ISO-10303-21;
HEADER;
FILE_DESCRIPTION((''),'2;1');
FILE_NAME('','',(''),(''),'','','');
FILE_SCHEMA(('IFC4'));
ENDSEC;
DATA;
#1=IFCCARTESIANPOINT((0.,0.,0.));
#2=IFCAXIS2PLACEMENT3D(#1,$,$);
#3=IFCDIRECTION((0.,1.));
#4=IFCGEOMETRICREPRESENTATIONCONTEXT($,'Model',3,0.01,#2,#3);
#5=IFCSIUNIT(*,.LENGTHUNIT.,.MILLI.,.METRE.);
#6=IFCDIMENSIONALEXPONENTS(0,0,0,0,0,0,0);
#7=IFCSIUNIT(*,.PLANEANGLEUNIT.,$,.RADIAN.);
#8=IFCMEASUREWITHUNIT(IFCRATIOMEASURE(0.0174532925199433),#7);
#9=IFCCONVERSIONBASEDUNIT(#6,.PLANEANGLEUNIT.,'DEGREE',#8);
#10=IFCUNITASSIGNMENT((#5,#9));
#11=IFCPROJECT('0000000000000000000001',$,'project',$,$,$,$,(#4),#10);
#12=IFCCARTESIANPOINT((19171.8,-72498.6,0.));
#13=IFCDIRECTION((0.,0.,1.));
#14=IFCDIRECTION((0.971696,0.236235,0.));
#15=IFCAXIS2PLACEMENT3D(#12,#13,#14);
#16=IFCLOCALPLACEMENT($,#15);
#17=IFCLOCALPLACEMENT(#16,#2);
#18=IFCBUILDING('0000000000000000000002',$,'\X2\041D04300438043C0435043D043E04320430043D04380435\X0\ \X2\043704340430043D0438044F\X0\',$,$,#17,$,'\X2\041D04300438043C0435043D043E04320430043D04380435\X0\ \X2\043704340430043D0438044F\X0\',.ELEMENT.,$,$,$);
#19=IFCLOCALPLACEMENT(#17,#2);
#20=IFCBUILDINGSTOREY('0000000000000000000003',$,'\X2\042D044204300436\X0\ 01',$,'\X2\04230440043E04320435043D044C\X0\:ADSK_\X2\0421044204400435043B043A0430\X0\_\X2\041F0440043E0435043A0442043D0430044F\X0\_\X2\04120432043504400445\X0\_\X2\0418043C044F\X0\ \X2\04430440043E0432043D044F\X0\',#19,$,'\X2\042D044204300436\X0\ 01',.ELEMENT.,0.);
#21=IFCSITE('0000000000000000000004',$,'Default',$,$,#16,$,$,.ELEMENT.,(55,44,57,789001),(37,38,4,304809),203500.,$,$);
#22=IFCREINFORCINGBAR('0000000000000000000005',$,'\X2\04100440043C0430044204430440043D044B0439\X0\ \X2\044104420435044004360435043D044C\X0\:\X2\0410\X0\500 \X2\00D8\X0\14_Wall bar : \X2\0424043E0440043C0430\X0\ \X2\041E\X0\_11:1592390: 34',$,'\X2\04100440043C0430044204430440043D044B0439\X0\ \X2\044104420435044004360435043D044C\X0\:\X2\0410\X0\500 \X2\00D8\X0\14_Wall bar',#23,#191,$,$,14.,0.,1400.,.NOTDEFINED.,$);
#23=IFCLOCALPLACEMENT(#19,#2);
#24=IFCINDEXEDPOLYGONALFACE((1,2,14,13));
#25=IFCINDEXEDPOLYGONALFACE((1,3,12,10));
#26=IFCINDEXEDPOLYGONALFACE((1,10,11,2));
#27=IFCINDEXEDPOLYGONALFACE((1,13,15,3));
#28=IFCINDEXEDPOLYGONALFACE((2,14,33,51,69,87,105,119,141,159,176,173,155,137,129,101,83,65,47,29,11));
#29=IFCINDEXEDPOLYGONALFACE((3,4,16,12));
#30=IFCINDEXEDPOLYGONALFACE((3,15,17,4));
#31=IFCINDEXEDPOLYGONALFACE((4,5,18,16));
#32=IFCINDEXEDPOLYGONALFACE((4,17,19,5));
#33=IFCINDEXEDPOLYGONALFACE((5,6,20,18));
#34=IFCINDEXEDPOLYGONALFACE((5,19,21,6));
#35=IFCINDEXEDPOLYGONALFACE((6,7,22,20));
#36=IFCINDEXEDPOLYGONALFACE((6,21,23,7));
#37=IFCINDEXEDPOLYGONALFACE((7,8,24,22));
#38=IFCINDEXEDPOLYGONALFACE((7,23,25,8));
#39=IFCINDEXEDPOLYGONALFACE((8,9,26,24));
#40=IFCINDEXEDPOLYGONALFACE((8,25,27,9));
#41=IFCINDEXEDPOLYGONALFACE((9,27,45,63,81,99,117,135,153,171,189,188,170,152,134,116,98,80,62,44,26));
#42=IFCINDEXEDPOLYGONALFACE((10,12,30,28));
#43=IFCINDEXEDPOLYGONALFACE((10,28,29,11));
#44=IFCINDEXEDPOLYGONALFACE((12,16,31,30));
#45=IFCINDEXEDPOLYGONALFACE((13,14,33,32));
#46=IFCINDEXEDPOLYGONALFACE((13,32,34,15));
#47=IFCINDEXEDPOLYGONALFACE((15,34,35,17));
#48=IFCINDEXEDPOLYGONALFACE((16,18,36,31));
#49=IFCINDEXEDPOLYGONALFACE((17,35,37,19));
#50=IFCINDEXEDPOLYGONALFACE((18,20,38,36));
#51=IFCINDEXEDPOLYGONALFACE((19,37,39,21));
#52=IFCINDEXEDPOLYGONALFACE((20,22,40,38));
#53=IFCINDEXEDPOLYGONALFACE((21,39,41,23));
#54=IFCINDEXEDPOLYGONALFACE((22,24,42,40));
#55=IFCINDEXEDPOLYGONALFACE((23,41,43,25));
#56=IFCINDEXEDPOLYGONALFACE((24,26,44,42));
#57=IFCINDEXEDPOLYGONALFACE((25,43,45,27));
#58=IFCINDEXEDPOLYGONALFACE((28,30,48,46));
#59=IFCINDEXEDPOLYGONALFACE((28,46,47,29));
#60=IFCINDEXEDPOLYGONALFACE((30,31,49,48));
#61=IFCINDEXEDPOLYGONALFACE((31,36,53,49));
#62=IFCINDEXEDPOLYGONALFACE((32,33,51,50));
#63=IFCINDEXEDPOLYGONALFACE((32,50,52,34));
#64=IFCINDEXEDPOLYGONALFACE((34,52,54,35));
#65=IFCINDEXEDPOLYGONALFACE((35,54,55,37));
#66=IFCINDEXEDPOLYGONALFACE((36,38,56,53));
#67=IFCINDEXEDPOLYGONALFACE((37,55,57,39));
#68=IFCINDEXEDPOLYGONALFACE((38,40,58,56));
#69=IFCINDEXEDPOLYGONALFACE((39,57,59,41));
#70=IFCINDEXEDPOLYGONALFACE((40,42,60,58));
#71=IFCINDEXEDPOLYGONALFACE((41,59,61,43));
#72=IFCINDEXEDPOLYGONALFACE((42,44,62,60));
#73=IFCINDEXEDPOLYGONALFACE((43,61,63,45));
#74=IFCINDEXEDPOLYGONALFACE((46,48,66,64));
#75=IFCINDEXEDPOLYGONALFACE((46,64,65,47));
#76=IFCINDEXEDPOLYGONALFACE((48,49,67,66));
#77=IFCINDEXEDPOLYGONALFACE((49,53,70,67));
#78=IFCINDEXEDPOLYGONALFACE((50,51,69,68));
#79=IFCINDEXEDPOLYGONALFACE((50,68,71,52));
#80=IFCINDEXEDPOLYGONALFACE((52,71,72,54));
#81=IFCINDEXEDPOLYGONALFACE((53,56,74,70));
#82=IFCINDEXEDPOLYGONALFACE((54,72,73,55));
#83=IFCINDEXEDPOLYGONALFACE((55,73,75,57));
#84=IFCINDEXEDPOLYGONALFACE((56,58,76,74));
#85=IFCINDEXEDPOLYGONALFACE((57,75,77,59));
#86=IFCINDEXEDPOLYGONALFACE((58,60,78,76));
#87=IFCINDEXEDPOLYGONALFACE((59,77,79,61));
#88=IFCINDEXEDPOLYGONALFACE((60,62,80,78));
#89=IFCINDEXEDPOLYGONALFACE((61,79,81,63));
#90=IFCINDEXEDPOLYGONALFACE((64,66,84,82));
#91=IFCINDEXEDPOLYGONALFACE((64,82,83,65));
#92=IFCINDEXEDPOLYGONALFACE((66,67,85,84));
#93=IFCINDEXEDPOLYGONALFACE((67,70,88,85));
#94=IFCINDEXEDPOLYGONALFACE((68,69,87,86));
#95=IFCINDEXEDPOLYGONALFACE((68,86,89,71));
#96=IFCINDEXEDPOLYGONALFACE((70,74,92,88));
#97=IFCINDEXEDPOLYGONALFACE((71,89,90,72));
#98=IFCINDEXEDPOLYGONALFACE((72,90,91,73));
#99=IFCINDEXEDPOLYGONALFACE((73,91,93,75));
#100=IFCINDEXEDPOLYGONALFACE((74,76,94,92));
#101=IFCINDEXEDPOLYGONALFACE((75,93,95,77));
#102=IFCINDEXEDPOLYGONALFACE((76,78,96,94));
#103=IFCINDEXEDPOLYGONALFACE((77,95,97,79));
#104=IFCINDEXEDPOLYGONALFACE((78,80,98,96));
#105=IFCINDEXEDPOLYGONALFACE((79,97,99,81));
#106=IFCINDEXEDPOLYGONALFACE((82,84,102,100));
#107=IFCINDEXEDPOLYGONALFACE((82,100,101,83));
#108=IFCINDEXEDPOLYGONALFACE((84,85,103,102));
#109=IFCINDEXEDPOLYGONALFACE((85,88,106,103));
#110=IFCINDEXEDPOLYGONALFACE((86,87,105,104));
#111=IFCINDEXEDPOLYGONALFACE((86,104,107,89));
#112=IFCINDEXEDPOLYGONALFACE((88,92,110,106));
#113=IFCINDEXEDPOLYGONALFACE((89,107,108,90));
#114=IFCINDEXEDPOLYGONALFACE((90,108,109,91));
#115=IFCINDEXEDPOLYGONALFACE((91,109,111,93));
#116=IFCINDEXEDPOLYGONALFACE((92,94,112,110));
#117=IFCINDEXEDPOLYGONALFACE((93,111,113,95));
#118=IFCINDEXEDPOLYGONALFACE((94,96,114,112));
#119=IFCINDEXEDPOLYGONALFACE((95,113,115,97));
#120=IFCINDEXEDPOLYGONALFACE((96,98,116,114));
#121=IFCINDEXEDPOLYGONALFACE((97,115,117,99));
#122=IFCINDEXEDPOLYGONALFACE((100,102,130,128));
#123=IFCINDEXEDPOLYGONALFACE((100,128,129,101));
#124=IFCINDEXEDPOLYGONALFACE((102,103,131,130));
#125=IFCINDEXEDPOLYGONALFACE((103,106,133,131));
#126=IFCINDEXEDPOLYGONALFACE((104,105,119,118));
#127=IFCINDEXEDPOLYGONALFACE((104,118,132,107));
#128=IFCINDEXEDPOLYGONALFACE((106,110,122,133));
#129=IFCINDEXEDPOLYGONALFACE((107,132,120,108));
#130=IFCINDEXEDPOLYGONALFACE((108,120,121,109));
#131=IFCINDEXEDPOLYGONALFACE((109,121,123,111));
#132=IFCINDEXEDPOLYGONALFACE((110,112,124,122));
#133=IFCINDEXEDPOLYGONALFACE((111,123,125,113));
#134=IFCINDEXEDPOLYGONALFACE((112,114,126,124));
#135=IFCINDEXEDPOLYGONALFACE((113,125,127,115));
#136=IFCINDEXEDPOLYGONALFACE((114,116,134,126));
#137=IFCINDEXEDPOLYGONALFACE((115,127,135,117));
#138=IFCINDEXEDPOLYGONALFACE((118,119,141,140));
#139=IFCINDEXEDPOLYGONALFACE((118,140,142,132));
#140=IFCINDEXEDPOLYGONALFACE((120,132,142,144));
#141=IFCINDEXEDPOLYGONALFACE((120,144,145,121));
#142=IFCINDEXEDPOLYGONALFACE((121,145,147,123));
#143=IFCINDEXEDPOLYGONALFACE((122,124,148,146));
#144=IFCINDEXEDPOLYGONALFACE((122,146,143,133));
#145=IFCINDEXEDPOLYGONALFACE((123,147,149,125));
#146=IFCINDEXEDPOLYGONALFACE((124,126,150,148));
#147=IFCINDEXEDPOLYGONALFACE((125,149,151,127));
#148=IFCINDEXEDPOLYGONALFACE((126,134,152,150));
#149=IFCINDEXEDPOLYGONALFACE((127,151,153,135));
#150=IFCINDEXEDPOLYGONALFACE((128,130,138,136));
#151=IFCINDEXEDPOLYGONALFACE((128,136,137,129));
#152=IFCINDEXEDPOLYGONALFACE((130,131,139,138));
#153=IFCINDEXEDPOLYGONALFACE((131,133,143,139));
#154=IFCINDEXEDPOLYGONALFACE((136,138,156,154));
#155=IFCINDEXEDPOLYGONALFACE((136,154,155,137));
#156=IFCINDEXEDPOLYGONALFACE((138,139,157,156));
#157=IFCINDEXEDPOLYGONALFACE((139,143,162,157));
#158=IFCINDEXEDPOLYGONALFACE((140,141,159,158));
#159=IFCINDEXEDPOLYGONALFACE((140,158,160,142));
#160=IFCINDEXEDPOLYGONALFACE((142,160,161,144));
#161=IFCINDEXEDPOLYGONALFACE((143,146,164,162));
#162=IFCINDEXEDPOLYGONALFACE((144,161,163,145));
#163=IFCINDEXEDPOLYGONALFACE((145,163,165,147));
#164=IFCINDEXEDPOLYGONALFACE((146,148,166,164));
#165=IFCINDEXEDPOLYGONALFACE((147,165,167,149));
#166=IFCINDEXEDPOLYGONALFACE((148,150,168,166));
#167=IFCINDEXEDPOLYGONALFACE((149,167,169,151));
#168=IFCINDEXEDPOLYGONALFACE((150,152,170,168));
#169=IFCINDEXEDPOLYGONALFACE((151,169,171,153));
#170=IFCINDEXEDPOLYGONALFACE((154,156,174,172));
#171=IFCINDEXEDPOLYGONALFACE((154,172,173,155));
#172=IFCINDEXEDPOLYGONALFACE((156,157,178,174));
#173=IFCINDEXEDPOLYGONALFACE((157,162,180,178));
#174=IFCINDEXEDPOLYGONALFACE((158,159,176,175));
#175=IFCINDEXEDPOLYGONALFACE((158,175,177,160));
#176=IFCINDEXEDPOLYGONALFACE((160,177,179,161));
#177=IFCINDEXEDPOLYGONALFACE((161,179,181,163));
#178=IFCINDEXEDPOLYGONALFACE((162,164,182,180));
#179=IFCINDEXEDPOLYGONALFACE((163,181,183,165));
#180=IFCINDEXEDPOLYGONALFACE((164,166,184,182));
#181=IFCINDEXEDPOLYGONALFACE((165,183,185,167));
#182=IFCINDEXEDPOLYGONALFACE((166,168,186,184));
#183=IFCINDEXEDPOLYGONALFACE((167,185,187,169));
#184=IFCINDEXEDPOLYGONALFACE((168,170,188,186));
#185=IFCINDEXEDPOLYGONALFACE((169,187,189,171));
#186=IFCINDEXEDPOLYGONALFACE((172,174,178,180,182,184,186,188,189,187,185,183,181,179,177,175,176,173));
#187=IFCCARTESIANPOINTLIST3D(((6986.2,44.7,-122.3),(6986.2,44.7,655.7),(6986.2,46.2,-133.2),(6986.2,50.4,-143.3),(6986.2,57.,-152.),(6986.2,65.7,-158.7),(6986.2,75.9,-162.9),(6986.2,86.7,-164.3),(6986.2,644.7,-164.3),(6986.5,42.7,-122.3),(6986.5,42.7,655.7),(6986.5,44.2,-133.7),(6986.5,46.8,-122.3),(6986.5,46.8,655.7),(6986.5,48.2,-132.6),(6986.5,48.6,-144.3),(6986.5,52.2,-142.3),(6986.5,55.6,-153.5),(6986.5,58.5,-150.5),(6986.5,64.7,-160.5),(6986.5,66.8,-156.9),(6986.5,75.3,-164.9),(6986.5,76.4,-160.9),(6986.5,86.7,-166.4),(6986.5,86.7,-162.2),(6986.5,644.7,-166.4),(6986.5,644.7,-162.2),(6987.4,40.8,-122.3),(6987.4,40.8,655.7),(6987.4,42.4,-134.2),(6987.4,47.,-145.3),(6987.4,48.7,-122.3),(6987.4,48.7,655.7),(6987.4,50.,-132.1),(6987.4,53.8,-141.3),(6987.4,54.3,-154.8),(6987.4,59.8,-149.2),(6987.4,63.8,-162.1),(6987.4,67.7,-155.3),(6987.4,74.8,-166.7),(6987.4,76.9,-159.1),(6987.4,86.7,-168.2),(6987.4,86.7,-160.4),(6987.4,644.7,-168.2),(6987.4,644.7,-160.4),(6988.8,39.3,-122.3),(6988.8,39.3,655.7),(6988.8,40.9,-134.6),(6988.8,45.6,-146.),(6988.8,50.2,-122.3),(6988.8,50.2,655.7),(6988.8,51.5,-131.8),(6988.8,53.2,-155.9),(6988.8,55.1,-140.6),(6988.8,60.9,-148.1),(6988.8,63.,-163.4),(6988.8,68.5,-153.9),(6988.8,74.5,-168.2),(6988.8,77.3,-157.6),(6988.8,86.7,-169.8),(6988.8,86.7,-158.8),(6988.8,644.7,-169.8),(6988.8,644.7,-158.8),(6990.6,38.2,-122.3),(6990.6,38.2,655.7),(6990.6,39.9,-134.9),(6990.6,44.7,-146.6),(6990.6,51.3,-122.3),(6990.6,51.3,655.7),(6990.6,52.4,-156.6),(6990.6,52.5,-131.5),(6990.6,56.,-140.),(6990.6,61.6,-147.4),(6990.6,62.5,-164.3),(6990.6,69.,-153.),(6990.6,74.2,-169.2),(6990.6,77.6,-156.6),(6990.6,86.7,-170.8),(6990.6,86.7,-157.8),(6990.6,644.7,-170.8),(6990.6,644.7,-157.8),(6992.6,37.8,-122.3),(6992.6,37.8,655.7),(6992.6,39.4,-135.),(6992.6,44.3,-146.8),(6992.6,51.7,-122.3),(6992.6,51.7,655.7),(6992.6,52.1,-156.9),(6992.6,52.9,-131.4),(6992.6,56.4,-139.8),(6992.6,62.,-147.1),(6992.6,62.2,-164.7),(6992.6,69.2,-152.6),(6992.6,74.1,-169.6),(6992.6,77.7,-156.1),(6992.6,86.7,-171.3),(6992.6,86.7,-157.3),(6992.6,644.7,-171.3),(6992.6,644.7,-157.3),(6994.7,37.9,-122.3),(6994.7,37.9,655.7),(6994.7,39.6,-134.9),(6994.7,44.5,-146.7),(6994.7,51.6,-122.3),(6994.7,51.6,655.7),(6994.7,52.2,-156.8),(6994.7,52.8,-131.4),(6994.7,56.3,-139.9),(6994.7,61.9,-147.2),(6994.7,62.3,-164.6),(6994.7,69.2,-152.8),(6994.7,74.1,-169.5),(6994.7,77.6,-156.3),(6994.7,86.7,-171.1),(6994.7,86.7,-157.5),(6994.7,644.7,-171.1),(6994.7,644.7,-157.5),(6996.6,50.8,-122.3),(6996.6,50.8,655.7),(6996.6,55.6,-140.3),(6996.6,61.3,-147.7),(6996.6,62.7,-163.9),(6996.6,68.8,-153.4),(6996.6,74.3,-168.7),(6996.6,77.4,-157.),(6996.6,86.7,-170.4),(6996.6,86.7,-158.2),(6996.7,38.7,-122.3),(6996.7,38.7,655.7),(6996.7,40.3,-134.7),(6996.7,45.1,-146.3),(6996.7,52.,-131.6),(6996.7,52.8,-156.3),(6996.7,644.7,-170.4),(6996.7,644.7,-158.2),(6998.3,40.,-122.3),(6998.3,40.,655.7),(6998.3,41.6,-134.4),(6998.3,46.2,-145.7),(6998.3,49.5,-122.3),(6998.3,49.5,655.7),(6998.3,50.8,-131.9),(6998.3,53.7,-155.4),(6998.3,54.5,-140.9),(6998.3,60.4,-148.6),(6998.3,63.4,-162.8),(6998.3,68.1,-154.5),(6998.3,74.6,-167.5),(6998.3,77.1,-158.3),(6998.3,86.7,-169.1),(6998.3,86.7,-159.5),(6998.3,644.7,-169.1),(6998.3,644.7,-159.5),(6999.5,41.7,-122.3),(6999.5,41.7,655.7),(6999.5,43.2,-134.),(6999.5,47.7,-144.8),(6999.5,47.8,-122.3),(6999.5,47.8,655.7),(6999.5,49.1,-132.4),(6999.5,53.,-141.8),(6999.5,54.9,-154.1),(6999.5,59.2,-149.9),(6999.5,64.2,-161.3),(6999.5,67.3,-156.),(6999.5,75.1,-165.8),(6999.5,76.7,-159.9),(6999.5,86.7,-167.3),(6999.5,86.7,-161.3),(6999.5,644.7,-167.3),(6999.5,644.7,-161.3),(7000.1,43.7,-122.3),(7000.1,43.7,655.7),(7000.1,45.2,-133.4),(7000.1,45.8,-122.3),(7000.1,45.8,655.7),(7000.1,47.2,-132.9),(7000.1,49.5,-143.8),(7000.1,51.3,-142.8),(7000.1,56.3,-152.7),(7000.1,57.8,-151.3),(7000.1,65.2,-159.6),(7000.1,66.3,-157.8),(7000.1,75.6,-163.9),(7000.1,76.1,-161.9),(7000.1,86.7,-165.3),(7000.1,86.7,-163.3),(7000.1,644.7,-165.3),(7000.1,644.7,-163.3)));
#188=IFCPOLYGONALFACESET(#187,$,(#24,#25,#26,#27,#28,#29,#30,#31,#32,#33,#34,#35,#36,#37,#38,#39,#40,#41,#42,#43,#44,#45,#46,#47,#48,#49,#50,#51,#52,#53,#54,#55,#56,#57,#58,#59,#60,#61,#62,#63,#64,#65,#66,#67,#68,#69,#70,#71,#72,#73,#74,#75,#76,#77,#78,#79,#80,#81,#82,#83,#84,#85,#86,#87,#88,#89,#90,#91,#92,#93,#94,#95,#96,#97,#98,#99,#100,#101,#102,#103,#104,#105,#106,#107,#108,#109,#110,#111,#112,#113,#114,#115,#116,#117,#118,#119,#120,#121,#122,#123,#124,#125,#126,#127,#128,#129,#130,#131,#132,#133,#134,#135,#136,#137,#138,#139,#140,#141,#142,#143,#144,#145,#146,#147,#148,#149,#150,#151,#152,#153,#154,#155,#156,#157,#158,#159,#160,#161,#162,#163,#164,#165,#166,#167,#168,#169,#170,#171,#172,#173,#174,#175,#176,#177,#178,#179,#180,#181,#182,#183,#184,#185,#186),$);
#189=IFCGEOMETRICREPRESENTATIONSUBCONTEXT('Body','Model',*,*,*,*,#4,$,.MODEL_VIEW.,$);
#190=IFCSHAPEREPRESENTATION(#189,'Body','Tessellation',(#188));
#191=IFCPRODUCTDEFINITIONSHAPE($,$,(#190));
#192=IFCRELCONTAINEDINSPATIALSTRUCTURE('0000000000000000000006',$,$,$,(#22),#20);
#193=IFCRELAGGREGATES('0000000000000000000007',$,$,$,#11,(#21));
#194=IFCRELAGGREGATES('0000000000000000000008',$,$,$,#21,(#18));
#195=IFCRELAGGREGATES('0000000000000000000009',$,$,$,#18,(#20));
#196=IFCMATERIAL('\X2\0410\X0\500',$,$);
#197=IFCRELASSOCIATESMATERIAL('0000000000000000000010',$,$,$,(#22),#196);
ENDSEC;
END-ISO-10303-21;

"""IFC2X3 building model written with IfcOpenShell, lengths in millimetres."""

from ifc_helpers import new_model, entity, si_unit, converted_unit, direction, frame, origin, place, context, subcontext, project, spatial, material, element, save


model = new_model("IFC2X3")

# Units and contexts
model_context = context("Model", 3, precision=0.01, world=origin(), true_north=direction((0.0, 1.0)))
body_context = subcontext(model_context, "Body", "Model", "MODEL_VIEW")
ifc_project = project(units=[si_unit("LENGTHUNIT", "METRE", prefix="MILLI"), converted_unit("PLANEANGLEUNIT", "DEGREE", entity("IfcRatioMeasure", 0.0174532925199433), si_unit("PLANEANGLEUNIT", "RADIAN"), dimensions=[0, 0, 0, 0, 0, 0, 0])], contexts=[model_context])

# Site, building, storey
site_placement = place(None, frame((19171.8, -72498.6, 0.0), z_axis=(0.0, 0.0, 1.0), x_axis=(0.971696, 0.236235, 0.0)))
site = spatial("IfcSite", under=ifc_project, at=site_placement, Name="Default", CompositionType="ELEMENT", RefLatitude=(55, 44, 57, 789001), RefLongitude=(37, 38, 4, 304809), RefElevation=203500.0)
building_placement = place(site_placement, origin())
building = spatial("IfcBuilding", under=site, at=building_placement, Name="Наименование здания", LongName="Наименование здания", CompositionType="ELEMENT")
storey_placement = place(building_placement, origin())
storey = spatial("IfcBuildingStorey", under=building, at=storey_placement, Name="Этаж 01", ObjectType="Уровень:ADSK_Стрелка_Проектная_Вверх_Имя уровня", LongName="Этаж 01", CompositionType="ELEMENT", Elevation=0.0)

# Reinforcing bar
ifc_material = material(Name="А500")
placement = place(storey_placement, origin())
element("IfcReinforcingBar", 1, at=placement, inside=storey, material=ifc_material, Name="Арматурный стержень:А500 Ø14_Wall bar : Форма О_11:1592390: 34", ObjectType="Арматурный стержень:А500 Ø14_Wall bar", BarLength=1400.0, BarRole="NOTDEFINED", CrossSectionArea=0.0, NominalDiameter=14.0, context=body_context, shape_type="AdvancedSweptSolid", body=[
    entity("IfcSweptDiskSolid", entity("IfcCompositeCurve", [entity("IfcCompositeCurveSegment", "CONTINUOUS", True, entity("IfcPolyline", [entity("IfcCartesianPoint", [6993.1, 44.7, 655.7]), entity("IfcCartesianPoint", [6993.1, 44.7, -122.3])])), entity("IfcCompositeCurveSegment", "CONTINUOUS", True, entity("IfcTrimmedCurve", entity("IfcCircle", entity("IfcAxis2Placement3D", entity("IfcCartesianPoint", [6993.1, 86.7, -122.3]), entity("IfcDirection", [1.0, 0.0, 0.0]), entity("IfcDirection", [0.0, 0.0, -1.0])), 42.0), [entity("IfcParameterValue", 270.0)], [entity("IfcParameterValue", 360.0)], True, "PARAMETER")), entity("IfcCompositeCurveSegment", "CONTINUOUS", True, entity("IfcPolyline", [entity("IfcCartesianPoint", [6993.1, 86.7, -164.3]), entity("IfcCartesianPoint", [6993.1, 644.7, -164.3])]))], False), 7.0, None, 0.0, 92.0),
])

save(model, "model.ifc")
